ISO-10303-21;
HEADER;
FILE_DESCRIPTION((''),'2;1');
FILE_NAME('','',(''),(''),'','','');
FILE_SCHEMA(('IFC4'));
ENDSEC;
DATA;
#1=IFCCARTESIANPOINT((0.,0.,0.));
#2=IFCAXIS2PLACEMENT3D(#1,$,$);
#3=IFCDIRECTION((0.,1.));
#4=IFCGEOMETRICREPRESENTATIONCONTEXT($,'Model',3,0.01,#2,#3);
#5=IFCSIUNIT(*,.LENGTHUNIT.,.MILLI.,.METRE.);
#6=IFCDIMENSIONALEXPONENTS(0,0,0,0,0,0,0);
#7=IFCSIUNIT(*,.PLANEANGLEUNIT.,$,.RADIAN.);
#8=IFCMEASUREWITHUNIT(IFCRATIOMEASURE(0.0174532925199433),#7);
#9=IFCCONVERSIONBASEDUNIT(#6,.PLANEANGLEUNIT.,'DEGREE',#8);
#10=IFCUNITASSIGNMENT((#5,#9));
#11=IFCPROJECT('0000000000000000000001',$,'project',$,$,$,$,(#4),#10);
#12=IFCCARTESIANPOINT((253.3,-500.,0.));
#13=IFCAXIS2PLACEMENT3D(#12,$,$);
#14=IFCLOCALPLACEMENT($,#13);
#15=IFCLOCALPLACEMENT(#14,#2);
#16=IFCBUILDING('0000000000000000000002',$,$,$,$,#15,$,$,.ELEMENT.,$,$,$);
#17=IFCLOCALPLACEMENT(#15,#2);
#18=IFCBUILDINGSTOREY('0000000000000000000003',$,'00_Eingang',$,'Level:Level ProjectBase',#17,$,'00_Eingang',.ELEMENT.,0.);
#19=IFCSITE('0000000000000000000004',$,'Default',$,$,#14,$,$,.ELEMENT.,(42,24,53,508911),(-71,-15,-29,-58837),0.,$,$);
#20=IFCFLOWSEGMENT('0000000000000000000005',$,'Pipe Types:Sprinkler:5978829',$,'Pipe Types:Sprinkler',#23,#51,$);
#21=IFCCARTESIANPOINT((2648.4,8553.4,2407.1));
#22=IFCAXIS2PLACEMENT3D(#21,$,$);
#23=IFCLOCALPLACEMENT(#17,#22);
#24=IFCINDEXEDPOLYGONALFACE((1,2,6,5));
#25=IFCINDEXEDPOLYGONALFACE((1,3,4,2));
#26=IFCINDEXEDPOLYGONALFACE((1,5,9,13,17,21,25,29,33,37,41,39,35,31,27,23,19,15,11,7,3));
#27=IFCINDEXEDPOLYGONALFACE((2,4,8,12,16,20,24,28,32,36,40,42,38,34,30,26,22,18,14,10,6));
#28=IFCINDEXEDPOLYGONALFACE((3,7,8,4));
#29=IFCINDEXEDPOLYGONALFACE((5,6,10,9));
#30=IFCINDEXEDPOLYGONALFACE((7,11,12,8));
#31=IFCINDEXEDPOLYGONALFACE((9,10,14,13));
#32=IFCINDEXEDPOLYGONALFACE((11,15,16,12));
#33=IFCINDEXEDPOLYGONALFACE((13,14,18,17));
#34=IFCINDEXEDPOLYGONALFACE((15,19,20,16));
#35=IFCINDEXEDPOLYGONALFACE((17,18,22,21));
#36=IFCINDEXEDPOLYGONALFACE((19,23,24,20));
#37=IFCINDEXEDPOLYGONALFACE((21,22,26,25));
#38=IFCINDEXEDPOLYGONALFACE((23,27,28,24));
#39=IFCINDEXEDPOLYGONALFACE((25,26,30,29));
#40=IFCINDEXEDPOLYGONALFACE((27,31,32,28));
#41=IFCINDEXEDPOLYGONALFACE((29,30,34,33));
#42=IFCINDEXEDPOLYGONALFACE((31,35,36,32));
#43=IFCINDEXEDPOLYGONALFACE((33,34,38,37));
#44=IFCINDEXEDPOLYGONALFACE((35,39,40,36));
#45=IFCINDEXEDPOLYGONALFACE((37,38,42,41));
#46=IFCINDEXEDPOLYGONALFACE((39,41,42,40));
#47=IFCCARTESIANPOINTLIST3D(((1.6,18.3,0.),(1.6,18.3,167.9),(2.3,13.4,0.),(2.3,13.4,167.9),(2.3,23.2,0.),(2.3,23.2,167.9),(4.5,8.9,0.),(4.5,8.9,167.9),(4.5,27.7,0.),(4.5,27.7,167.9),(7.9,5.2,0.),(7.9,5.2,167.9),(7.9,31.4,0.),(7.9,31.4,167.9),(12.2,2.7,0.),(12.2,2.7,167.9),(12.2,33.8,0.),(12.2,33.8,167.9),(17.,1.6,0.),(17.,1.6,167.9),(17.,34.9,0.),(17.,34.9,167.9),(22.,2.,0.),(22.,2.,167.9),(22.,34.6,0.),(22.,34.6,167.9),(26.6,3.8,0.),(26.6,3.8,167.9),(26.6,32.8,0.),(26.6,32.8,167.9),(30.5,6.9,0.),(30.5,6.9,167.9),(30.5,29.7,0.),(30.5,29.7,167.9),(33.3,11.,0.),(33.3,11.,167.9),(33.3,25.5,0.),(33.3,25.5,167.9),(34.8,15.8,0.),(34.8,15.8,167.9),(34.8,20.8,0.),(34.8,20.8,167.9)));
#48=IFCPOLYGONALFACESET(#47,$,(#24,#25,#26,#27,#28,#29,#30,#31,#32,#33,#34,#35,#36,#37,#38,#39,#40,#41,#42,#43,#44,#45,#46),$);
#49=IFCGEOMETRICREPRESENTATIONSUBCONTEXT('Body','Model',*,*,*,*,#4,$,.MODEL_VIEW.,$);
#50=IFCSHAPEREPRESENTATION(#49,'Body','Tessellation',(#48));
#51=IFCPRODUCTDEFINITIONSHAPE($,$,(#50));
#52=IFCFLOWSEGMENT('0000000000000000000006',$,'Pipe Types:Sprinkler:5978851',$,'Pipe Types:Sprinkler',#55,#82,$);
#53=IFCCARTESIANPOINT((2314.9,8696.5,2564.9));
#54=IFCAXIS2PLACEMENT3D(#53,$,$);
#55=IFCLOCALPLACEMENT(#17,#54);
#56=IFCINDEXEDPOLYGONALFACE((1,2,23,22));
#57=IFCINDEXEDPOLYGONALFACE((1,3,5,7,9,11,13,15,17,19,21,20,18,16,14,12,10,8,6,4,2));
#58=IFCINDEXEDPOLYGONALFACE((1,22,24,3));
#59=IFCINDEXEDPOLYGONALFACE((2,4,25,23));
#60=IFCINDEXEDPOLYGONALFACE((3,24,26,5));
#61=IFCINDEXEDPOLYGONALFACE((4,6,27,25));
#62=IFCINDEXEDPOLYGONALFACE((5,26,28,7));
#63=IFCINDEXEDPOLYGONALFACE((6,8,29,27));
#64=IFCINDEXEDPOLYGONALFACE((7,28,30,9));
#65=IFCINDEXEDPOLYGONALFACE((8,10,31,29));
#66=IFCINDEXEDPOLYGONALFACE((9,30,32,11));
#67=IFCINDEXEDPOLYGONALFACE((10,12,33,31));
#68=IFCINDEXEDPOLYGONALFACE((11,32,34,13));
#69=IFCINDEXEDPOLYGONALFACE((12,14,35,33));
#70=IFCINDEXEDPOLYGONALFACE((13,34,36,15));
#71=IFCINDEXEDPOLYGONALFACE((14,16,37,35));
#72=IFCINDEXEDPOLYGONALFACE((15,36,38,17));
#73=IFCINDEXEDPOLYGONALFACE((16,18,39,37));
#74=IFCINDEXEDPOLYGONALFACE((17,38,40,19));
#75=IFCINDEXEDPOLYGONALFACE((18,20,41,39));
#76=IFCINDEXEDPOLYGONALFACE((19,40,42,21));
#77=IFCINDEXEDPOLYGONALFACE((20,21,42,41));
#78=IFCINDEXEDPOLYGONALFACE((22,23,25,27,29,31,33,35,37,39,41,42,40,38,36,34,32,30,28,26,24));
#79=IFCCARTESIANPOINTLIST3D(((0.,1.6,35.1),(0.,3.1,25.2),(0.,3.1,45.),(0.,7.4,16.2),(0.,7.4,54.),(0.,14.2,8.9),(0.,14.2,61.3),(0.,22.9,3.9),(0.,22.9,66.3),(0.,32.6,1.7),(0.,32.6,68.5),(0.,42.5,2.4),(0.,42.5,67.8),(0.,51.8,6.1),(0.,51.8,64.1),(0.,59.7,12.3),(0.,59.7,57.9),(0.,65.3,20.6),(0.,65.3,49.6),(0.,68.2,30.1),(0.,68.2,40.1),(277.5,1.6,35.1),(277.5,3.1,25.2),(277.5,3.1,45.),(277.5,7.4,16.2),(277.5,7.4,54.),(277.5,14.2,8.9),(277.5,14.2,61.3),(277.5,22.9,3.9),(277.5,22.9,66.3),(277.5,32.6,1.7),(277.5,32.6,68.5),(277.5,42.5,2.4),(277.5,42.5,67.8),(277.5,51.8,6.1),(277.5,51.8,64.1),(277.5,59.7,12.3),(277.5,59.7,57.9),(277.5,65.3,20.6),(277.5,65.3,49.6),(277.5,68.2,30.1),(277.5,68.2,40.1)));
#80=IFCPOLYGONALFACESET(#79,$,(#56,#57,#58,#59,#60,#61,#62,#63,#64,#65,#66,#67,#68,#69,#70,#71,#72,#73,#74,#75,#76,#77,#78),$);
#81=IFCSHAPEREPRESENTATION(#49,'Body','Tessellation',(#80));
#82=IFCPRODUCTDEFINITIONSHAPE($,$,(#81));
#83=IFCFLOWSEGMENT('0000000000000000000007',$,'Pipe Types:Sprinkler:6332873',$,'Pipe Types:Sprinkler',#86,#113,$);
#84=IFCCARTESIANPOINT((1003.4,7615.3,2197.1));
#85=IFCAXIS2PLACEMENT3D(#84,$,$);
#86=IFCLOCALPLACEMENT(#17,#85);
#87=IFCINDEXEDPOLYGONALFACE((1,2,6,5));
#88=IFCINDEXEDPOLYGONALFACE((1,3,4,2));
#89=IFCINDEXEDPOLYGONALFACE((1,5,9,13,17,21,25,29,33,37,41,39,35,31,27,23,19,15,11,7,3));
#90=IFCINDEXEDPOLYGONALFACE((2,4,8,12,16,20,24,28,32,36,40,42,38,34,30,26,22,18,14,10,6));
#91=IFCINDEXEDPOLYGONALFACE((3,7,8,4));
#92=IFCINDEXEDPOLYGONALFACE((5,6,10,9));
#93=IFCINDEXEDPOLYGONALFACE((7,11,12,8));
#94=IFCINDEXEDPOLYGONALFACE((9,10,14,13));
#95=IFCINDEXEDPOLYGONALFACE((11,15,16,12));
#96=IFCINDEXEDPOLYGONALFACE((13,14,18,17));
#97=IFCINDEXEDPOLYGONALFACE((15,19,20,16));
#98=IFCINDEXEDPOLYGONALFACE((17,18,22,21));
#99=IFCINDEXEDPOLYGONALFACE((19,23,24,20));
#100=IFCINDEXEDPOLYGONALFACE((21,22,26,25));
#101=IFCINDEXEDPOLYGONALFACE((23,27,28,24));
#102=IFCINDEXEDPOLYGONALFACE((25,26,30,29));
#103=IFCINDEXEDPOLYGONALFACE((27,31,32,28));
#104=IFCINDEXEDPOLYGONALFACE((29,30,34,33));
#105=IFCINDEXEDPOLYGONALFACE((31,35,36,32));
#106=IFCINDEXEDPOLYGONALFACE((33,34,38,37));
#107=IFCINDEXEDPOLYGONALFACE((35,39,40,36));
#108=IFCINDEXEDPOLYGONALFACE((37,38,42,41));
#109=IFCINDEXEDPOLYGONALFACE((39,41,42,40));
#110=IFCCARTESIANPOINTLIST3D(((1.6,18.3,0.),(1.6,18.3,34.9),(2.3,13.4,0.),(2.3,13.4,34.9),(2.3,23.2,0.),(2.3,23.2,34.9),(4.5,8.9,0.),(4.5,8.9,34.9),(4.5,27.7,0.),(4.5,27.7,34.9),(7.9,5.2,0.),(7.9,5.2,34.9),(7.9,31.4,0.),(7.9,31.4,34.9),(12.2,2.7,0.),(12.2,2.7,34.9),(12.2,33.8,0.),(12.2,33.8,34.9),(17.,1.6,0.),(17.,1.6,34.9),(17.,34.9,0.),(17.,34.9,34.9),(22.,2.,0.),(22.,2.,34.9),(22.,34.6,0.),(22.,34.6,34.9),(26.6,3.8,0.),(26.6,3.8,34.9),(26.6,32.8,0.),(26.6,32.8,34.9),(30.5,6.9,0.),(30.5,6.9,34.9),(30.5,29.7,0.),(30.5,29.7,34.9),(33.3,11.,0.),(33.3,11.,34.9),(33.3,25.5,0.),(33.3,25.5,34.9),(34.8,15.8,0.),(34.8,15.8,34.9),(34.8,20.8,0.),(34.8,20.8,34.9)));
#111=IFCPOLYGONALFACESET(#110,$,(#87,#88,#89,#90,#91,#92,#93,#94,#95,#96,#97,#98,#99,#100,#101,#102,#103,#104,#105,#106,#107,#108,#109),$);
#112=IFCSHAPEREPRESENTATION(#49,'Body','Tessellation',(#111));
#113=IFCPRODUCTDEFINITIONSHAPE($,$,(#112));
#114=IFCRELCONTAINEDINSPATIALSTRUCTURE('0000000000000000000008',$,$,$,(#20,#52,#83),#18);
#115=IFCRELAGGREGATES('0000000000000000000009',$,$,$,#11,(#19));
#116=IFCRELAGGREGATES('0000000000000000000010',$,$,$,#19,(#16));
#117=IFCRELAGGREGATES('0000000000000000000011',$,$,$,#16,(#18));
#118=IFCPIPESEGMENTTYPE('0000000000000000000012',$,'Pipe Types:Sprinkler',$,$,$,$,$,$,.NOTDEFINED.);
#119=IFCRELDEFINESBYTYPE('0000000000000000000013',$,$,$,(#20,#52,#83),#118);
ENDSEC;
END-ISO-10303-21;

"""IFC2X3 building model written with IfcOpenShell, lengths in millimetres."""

from ifc_helpers import new_model, entity, si_unit, converted_unit, direction, frame, frame_2d, origin, origin_2d_with_axis, place, context, subcontext, project, spatial, circle, extrude, type_object, element, save


model = new_model("IFC2X3")

# Units and contexts
model_context = context("Model", 3, precision=0.01, world=origin(), true_north=direction((0.0, 1.0)))
body_context = subcontext(model_context, "Body", "Model", "MODEL_VIEW")
ifc_project = project(units=[si_unit("LENGTHUNIT", "METRE", prefix="MILLI"), converted_unit("PLANEANGLEUNIT", "DEGREE", entity("IfcRatioMeasure", 0.0174532925199433), si_unit("PLANEANGLEUNIT", "RADIAN"), dimensions=[0, 0, 0, 0, 0, 0, 0])], contexts=[model_context])

# Site, building, storey
site_placement = place(None, frame((253.3, -500.0, 0.0)))
site = spatial("IfcSite", under=ifc_project, at=site_placement, Name="Default", CompositionType="ELEMENT", RefLatitude=(42, 24, 53, 508911), RefLongitude=(-71, -15, -29, -58837), RefElevation=0.0)
building_placement = place(site_placement, origin())
building = spatial("IfcBuilding", under=site, at=building_placement, CompositionType="ELEMENT")
storey_placement = place(building_placement, origin())
storey = spatial("IfcBuildingStorey", under=building, at=storey_placement, Name="00_Eingang", ObjectType="Level:Level ProjectBase", LongName="00_Eingang", CompositionType="ELEMENT", Elevation=0.0)

# Flow segments
pipe_segment_type = type_object("IfcPipeSegmentType", Name="Pipe Types:Sprinkler", PredefinedType="NOTDEFINED")
flow_segment_1_placement = place(storey_placement, frame((2648.4, 8553.4, 2407.1)))
element("IfcFlowSegment", 1, at=flow_segment_1_placement, inside=storey, type_object=pipe_segment_type, Name="Pipe Types:Sprinkler:5978829", ObjectType="Pipe Types:Sprinkler", context=body_context, shape_type="SweptSolid", body=[
    extrude(circle(Radius=16.7, at=origin_2d_with_axis()), frame((18.3, 18.3, 0.0), z_axis=(0.0, 0.0, 1.0), x_axis=(-1.0, 0.0, 0.0)), (0.0, 0.0, 1.0), 167.9),
])
flow_segment_2_placement = place(storey_placement, frame((2314.9, 8696.5, 2564.9)))
element("IfcFlowSegment", 2, at=flow_segment_2_placement, inside=storey, type_object=pipe_segment_type, Name="Pipe Types:Sprinkler:5978851", ObjectType="Pipe Types:Sprinkler", context=body_context, shape_type="SweptSolid", body=[
    extrude(circle(Radius=33.5, at=origin_2d_with_axis()), frame((0.0, 35.1, 35.1), z_axis=(1.0, 0.0, 0.0), x_axis=(0.0, -1.0, 0.0)), (0.0, 0.0, 1.0), 277.5),
])
flow_segment_3_placement = place(storey_placement, frame((1003.4, 7615.3, 2197.1)))
element("IfcFlowSegment", 3, at=flow_segment_3_placement, inside=storey, type_object=pipe_segment_type, Name="Pipe Types:Sprinkler:6332873", ObjectType="Pipe Types:Sprinkler", context=body_context, shape_type="SweptSolid", body=[
    extrude(circle(Radius=16.7, at=frame_2d((0.0, 0.0), x_axis=(1.0, 0.0))), frame((18.3, 18.3, 0.0), z_axis=(0.0, 0.0, 1.0), x_axis=(-1.0, 0.0, 0.0)), (0.0, 0.0, 1.0), 34.9),
])

save(model, "model.ifc")
